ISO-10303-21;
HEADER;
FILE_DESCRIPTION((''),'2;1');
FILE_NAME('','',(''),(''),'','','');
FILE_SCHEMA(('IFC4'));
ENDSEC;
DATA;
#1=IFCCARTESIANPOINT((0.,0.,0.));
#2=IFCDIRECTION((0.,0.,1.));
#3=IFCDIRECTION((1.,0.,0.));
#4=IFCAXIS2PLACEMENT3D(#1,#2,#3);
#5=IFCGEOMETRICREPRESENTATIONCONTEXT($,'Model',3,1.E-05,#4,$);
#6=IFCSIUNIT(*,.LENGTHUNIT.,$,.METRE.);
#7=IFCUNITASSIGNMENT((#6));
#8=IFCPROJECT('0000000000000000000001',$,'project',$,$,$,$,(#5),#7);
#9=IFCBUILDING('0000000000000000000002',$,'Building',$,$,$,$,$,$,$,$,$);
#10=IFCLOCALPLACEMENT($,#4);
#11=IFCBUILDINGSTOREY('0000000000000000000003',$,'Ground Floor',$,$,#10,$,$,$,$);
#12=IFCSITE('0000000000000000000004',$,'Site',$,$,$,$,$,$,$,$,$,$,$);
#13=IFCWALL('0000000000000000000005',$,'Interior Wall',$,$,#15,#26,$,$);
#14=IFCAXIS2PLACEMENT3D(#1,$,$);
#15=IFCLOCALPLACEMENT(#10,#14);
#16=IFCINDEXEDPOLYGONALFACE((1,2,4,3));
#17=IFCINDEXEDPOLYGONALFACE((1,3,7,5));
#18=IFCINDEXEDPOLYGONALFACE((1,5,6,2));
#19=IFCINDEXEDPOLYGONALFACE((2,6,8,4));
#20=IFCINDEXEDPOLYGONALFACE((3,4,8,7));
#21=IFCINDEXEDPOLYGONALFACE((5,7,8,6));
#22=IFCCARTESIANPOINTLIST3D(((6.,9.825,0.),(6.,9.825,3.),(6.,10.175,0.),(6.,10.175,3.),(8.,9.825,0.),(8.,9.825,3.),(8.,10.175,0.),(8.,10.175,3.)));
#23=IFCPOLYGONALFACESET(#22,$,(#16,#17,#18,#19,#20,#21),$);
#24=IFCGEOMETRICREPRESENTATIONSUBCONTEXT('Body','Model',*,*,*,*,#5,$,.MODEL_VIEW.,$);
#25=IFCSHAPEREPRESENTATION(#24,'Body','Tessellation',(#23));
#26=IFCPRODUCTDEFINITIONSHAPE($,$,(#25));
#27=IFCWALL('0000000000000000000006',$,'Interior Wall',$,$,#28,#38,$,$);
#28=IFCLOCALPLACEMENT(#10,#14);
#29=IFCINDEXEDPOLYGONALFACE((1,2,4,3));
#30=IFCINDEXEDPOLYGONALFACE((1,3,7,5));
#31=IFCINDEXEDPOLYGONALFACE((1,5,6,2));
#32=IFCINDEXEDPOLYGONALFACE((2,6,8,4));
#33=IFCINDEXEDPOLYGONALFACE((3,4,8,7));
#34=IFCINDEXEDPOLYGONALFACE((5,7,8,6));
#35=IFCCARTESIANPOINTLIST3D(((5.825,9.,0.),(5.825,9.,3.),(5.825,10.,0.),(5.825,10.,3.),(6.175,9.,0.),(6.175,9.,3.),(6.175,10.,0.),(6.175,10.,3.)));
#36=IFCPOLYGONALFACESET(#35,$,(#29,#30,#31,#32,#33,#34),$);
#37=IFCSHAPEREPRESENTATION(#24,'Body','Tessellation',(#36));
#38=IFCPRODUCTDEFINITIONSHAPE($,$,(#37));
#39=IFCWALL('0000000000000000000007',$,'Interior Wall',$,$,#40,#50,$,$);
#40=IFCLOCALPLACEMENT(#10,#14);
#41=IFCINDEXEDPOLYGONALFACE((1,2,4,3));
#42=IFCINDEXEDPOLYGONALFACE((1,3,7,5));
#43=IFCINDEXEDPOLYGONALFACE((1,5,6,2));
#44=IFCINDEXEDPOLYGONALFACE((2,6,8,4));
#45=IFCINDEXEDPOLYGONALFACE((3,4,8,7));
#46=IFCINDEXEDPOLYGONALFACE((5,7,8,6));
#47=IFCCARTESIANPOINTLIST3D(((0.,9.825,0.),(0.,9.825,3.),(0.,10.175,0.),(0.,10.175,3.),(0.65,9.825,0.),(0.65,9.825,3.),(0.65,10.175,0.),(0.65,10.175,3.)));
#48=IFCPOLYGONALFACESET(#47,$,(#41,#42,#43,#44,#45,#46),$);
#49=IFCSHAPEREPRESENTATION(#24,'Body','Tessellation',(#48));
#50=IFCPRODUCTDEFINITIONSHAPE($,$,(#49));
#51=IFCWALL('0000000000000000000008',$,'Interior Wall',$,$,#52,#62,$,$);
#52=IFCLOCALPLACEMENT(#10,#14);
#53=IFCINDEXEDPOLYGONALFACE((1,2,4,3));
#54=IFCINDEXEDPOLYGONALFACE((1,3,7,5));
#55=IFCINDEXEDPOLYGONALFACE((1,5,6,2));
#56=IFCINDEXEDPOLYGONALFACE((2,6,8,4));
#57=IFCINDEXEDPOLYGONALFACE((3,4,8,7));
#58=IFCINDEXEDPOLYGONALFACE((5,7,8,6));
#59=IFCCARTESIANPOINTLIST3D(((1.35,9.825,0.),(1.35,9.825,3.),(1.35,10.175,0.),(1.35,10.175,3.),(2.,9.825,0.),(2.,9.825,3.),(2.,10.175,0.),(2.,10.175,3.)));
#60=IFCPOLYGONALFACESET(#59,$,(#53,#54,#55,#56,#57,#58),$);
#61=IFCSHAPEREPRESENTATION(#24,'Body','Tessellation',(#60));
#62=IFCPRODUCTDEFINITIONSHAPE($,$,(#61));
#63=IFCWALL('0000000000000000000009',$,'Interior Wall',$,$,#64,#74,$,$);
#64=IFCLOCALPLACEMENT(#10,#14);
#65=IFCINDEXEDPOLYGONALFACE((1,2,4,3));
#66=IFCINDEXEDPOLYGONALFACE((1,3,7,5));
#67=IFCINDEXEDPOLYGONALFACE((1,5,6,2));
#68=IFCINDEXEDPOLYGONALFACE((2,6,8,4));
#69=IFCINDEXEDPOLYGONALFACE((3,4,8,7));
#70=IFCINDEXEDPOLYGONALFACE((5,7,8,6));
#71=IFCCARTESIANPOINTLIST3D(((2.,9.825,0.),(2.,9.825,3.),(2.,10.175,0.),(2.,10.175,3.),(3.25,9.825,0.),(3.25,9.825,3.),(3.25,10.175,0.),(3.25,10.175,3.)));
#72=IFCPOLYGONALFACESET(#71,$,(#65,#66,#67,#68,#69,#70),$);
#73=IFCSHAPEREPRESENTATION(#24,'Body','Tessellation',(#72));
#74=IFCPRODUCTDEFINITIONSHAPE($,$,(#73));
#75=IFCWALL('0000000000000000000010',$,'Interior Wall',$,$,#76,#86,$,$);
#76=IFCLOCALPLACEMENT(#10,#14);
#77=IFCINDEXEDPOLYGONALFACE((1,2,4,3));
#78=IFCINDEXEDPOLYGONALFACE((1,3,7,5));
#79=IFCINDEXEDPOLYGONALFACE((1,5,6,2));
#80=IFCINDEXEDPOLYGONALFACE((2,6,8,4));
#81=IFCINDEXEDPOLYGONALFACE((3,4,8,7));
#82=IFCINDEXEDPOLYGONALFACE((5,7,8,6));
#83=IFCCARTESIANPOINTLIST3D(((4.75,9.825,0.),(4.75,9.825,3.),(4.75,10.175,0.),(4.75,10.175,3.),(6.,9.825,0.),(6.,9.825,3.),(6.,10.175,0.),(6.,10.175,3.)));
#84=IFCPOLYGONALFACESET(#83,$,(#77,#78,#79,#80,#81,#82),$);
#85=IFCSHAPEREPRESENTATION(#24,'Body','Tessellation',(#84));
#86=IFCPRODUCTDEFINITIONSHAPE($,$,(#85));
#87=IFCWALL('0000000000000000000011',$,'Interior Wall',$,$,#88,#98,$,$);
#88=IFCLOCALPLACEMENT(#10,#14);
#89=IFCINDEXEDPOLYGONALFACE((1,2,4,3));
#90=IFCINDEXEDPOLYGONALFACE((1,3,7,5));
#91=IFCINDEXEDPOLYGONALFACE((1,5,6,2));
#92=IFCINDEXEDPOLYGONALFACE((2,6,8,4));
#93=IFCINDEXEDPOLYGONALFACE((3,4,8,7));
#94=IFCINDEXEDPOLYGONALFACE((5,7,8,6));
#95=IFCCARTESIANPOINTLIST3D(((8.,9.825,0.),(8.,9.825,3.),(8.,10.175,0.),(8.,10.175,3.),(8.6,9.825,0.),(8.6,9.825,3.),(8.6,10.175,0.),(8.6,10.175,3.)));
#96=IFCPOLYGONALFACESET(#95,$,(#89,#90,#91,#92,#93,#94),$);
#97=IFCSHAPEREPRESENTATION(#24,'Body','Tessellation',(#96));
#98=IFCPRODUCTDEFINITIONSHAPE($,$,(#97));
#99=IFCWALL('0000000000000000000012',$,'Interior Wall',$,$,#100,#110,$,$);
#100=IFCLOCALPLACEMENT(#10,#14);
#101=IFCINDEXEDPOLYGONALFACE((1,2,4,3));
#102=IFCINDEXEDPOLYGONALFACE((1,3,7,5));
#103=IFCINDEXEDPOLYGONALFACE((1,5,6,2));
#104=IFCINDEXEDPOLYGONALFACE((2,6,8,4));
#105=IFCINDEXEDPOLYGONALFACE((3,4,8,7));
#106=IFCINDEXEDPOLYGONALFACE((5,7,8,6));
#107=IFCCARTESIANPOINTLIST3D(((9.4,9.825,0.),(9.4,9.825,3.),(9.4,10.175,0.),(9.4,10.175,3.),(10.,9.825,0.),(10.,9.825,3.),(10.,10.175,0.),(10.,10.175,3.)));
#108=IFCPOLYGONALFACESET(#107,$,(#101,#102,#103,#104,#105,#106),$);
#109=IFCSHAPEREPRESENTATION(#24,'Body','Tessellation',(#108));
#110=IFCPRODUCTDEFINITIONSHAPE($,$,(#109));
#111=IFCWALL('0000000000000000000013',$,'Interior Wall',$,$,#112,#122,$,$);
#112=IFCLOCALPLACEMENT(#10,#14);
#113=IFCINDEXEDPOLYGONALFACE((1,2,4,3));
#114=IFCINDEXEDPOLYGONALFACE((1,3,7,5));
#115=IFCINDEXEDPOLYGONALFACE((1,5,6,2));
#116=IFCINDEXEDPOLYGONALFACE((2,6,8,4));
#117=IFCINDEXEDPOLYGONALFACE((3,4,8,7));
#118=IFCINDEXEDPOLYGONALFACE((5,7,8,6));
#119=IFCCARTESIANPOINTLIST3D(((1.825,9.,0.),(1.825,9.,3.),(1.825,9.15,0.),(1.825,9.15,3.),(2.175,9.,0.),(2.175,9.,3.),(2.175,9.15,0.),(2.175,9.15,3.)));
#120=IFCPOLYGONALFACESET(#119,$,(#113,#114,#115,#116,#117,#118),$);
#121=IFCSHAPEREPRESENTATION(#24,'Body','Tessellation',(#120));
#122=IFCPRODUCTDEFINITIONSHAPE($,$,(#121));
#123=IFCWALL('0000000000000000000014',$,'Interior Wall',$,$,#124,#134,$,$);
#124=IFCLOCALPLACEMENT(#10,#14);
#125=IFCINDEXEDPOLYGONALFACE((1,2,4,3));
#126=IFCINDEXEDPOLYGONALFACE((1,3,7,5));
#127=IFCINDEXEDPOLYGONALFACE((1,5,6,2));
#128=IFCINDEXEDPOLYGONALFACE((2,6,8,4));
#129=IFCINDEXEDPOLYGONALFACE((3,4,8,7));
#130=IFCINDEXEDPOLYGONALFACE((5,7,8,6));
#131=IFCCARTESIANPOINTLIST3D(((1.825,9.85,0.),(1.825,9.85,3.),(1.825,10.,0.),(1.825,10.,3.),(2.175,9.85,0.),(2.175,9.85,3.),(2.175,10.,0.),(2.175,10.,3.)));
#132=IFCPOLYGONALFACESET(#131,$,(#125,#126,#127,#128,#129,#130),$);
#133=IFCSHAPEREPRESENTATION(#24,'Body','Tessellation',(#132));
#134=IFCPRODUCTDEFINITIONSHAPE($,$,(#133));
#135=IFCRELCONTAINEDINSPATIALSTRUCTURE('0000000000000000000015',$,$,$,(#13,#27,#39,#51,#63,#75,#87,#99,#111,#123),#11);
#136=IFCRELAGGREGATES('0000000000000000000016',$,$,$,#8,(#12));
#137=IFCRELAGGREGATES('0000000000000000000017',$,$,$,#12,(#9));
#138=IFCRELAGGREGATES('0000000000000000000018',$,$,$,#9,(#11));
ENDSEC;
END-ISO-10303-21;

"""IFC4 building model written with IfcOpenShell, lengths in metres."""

from ifc_helpers import new_model, si_unit, frame, origin_with_axes, place, context, subcontext, project, spatial, indexed_curve, outline, extrude, element, save


model = new_model("IFC4")

# Units and contexts
model_context = context("Model", 3, precision=1e-05, world=origin_with_axes())
body_context = subcontext(model_context, "Body", "Model", "MODEL_VIEW")
ifc_project = project(units=[si_unit("LENGTHUNIT", "METRE")], contexts=[model_context])

# Site, building, storey
site = spatial("IfcSite", under=ifc_project, Name="Site")
building = spatial("IfcBuilding", under=site, Name="Building")
storey_placement = place(None, origin_with_axes())
storey = spatial("IfcBuildingStorey", under=building, at=storey_placement, Name="Ground Floor")

# Walls
wall_1_placement = place(storey_placement, frame((8.0, 10.0, 0.0), z_axis=(0.0, 0.0, 1.0), x_axis=(-1.0, 0.0, 0.0)))
element("IfcWall", 1, at=wall_1_placement, inside=storey, Name="Interior Wall", context=body_context, shape_type="SweptSolid", body=[
    extrude(outline(indexed_curve([(0.0, 0.0), (0.0, 0.35), (2.0, 0.35), (2.0, 0.0), (0.0, 0.0)], self_intersect=False)), frame((0.0, -0.175, 0.0), z_axis=(0.0, 0.0, 1.0), x_axis=(1.0, 0.0, 0.0)), (0.0, 0.0, 1.0), 3.0),
])
wall_2_placement = place(storey_placement, frame((6.0, 10.0, 0.0), z_axis=(0.0, 0.0, 1.0), x_axis=(0.0, -1.0, 0.0)))
element("IfcWall", 2, at=wall_2_placement, inside=storey, Name="Interior Wall", context=body_context, shape_type="SweptSolid", body=[
    extrude(outline(indexed_curve([(0.0, 0.0), (0.0, 0.35), (1.0, 0.35), (1.0, 0.0), (0.0, 0.0)], self_intersect=False)), frame((0.0, -0.175, 0.0), z_axis=(0.0, 0.0, 1.0), x_axis=(1.0, 0.0, 0.0)), (0.0, 0.0, 1.0), 3.0),
])
wall_3_placement = place(storey_placement, frame((0.0, 10.0, 0.0), z_axis=(0.0, 0.0, 1.0), x_axis=(1.0, 0.0, 0.0)))
element("IfcWall", 3, at=wall_3_placement, inside=storey, Name="Interior Wall", context=body_context, shape_type="SweptSolid", body=[
    extrude(outline(indexed_curve([(0.0, 0.0), (0.0, 0.35), (0.65, 0.35), (0.65, 0.0), (0.0, 0.0)], self_intersect=False)), frame((0.0, -0.175, 0.0), z_axis=(0.0, 0.0, 1.0), x_axis=(1.0, 0.0, 0.0)), (0.0, 0.0, 1.0), 3.0),
])
wall_4_placement = place(storey_placement, frame((1.35, 10.0, 0.0), z_axis=(0.0, 0.0, 1.0), x_axis=(1.0, 0.0, 0.0)))
element("IfcWall", 4, at=wall_4_placement, inside=storey, Name="Interior Wall", context=body_context, shape_type="SweptSolid", body=[
    extrude(outline(indexed_curve([(0.0, 0.0), (0.0, 0.35), (0.65, 0.35), (0.65, 0.0), (0.0, 0.0)], self_intersect=False)), frame((0.0, -0.175, 0.0), z_axis=(0.0, 0.0, 1.0), x_axis=(1.0, 0.0, 0.0)), (0.0, 0.0, 1.0), 3.0),
])
for number, where, z_axis, x_axis, name in (
    (5, (2.0, 10.0, 0.0), (0.0, 0.0, 1.0), (1.0, 0.0, 0.0), "Interior Wall"),
    (6, (4.75, 10.0, 0.0), (0.0, 0.0, 1.0), (1.0, 0.0, 0.0), "Interior Wall"),
):
    element("IfcWall", number, at=place(storey_placement, frame(where, z_axis=z_axis, x_axis=x_axis)), inside=storey, Name=name, context=body_context, shape_type="SweptSolid", body=[
        extrude(outline(indexed_curve([(0.0, 0.0), (0.0, 0.35), (1.25, 0.35), (1.25, 0.0), (0.0, 0.0)], self_intersect=False)), frame((0.0, -0.175, 0.0), z_axis=(0.0, 0.0, 1.0), x_axis=(1.0, 0.0, 0.0)), (0.0, 0.0, 1.0), 3.0),
    ])
for number, where, z_axis, x_axis, name in (
    (7, (8.0, 10.0, 0.0), (0.0, 0.0, 1.0), (1.0, 0.0, 0.0), "Interior Wall"),
    (8, (9.4, 10.0, 0.0), (0.0, 0.0, 1.0), (1.0, 0.0, 0.0), "Interior Wall"),
):
    element("IfcWall", number, at=place(storey_placement, frame(where, z_axis=z_axis, x_axis=x_axis)), inside=storey, Name=name, context=body_context, shape_type="SweptSolid", body=[
        extrude(outline(indexed_curve([(0.0, 0.0), (0.0, 0.35), (0.6, 0.35), (0.6, 0.0), (0.0, 0.0)], self_intersect=False)), frame((0.0, -0.175, 0.0), z_axis=(0.0, 0.0, 1.0), x_axis=(1.0, 0.0, 0.0)), (0.0, 0.0, 1.0), 3.0),
    ])
for number, where, z_axis, x_axis, name in (
    (9, (2.0, 9.0, 0.0), (0.0, 0.0, 1.0), (0.0, 1.0, 0.0), "Interior Wall"),
    (10, (2.0, 9.85, 0.0), (0.0, 0.0, 1.0), (0.0, 1.0, 0.0), "Interior Wall"),
):
    element("IfcWall", number, at=place(storey_placement, frame(where, z_axis=z_axis, x_axis=x_axis)), inside=storey, Name=name, context=body_context, shape_type="SweptSolid", body=[
        extrude(outline(indexed_curve([(0.0, 0.0), (0.0, 0.35), (0.15, 0.35), (0.15, 0.0), (0.0, 0.0)], self_intersect=False)), frame((0.0, -0.175, 0.0), z_axis=(0.0, 0.0, 1.0), x_axis=(1.0, 0.0, 0.0)), (0.0, 0.0, 1.0), 3.0),
    ])

save(model, "model.ifc")
